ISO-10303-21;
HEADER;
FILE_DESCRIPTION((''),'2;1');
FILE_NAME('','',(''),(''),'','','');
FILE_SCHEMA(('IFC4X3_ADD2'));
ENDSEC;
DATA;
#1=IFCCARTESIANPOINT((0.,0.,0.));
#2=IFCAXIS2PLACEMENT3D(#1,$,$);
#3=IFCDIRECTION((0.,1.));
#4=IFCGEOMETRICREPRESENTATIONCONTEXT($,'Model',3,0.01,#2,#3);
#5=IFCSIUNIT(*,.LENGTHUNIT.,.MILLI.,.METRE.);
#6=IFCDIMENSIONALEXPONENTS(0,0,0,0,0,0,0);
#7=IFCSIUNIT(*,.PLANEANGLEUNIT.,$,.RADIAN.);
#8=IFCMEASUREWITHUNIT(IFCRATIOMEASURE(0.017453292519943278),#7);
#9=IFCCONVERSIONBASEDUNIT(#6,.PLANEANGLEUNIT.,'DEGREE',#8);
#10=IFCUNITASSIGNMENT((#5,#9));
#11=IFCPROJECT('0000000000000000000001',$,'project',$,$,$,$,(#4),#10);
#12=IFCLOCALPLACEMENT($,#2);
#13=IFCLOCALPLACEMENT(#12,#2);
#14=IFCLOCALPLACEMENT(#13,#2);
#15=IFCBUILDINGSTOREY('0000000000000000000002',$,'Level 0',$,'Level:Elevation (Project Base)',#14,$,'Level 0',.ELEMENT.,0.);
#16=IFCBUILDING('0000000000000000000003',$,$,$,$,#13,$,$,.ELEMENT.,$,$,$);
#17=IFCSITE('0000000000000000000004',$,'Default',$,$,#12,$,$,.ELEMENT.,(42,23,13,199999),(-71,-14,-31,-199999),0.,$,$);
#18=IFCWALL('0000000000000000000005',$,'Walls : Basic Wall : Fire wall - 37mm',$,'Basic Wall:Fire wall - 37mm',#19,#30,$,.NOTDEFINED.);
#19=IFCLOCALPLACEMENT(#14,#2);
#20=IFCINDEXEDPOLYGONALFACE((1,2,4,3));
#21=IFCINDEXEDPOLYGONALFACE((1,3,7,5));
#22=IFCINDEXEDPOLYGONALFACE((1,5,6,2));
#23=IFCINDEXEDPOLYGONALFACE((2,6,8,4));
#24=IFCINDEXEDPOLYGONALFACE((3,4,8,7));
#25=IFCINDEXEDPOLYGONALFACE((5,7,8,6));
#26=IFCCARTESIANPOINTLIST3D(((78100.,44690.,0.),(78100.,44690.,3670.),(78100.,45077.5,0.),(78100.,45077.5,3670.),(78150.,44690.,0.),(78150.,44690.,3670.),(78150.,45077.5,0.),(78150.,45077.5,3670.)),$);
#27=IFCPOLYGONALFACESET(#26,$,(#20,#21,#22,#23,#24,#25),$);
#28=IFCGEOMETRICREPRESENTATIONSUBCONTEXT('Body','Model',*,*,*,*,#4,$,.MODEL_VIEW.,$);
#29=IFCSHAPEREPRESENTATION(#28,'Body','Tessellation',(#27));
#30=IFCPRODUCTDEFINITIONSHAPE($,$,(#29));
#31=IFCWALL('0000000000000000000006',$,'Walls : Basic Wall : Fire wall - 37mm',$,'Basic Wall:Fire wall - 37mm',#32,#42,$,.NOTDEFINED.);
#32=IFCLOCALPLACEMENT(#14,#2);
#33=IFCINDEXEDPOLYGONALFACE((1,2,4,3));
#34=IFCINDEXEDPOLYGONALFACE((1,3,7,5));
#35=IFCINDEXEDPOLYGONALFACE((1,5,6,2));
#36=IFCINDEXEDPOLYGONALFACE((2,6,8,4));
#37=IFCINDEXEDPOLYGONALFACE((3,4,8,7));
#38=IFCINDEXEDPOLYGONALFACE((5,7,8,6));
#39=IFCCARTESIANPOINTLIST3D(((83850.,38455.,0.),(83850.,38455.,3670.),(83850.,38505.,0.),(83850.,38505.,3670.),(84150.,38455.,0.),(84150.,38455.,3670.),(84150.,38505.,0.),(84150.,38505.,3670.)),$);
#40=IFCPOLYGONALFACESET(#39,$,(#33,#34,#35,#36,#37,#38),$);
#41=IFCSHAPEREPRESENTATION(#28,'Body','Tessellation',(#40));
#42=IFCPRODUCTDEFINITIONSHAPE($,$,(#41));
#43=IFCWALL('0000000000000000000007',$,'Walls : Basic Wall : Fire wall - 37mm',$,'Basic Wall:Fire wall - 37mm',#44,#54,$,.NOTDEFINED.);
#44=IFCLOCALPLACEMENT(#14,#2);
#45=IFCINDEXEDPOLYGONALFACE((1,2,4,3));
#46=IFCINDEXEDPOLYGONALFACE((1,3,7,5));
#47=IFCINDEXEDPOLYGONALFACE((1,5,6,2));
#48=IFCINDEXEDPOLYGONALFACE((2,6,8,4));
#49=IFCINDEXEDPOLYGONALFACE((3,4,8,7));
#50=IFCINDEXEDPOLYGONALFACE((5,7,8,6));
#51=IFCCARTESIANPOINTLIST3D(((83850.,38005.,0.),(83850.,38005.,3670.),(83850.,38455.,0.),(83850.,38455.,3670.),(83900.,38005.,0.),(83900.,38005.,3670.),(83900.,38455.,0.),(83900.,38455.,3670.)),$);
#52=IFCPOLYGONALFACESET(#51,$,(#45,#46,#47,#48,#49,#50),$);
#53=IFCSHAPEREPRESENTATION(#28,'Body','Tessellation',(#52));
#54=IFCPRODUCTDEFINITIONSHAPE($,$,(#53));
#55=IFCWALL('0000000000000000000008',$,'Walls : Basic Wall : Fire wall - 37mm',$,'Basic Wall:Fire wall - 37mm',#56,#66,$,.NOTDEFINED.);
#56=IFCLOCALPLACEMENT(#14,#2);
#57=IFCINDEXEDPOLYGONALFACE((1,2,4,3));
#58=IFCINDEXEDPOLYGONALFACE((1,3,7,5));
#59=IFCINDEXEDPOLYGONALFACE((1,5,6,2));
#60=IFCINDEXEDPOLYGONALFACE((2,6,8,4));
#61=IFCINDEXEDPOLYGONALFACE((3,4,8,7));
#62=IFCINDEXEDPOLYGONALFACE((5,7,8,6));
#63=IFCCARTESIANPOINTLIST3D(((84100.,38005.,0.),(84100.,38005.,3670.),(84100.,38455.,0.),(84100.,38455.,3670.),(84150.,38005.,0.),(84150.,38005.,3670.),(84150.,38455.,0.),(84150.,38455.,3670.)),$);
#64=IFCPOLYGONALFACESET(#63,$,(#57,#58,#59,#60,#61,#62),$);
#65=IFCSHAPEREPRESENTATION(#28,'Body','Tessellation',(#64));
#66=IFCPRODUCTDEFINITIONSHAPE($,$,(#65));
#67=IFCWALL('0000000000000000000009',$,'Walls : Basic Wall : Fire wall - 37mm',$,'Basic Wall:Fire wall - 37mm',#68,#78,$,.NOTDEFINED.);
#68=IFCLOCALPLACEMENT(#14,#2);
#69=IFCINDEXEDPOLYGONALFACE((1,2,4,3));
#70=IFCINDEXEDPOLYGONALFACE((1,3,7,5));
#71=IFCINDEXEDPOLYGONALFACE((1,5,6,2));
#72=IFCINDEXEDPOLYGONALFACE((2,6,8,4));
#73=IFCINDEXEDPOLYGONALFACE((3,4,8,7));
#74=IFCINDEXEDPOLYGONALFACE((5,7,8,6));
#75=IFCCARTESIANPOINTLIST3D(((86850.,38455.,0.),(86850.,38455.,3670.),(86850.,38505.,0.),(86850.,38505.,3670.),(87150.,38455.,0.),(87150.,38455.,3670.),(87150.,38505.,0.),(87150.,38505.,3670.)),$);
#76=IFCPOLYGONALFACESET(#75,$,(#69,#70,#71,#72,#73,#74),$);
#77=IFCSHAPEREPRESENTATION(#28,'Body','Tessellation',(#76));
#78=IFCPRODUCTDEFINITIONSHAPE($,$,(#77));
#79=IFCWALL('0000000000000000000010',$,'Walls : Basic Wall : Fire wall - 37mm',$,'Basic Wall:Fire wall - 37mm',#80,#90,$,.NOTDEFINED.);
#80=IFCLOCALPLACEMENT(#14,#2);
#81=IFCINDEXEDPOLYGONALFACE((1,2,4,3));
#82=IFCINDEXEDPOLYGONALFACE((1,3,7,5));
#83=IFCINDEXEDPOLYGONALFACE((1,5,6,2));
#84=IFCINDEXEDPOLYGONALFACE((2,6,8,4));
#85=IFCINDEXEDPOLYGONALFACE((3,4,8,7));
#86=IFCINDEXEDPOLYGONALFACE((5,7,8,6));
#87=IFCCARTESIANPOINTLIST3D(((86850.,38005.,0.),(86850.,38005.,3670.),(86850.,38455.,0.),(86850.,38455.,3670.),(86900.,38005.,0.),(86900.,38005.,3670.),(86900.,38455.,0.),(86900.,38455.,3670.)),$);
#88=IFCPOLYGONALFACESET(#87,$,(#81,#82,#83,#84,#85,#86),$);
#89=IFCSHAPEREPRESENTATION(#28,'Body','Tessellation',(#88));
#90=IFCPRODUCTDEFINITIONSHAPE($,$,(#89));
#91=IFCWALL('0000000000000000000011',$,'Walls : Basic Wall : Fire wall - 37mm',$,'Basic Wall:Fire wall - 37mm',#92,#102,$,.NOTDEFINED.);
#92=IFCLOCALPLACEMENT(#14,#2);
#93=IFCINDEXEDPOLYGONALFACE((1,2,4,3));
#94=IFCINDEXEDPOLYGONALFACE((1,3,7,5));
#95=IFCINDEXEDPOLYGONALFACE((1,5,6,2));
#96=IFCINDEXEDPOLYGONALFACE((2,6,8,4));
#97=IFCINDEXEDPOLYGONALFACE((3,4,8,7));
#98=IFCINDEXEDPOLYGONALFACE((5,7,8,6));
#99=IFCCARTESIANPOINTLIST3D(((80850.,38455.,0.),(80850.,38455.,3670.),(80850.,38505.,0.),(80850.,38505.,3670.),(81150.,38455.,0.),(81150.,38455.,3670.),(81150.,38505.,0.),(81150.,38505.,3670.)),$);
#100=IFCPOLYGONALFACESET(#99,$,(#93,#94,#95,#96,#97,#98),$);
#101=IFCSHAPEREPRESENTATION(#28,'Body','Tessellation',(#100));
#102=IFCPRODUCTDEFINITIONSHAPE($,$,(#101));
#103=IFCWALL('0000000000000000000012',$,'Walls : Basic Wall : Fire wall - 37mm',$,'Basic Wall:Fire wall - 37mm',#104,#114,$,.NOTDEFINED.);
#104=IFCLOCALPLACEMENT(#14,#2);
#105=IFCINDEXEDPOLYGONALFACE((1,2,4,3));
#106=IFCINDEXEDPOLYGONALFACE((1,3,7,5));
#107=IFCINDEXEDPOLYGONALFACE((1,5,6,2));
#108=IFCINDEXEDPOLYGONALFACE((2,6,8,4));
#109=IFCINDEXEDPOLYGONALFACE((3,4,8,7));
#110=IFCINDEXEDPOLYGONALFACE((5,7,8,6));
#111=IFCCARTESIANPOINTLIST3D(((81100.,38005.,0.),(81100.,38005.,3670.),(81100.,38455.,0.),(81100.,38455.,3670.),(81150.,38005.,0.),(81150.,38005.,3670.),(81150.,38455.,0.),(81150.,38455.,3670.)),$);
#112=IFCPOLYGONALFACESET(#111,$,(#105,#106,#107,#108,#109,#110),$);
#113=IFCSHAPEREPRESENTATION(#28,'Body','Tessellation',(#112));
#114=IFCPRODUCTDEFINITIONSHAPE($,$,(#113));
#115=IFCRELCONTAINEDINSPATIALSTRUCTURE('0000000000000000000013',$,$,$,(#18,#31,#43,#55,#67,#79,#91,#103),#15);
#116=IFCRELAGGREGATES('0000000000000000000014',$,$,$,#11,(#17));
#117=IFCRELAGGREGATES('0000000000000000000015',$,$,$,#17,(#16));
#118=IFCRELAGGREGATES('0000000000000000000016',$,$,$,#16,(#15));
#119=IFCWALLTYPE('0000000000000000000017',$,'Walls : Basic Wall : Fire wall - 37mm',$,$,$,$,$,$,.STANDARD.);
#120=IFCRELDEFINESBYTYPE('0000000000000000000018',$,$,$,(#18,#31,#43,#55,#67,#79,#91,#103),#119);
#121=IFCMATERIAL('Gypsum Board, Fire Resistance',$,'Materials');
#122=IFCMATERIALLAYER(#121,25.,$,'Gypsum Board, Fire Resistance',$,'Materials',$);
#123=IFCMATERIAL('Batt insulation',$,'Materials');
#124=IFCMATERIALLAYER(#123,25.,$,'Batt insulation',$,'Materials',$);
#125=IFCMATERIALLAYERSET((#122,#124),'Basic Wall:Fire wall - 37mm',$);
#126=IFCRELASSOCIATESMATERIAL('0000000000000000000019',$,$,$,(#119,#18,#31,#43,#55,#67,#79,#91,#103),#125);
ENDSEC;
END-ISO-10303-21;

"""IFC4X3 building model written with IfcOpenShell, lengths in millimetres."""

from ifc_helpers import new_model, entity, si_unit, converted_unit, direction, frame, frame_2d, origin, place, context, subcontext, project, spatial, rectangle, extrude, material, layer, layer_set, type_object, element, save


model = new_model("IFC4X3")

# Units and contexts
model_context = context("Model", 3, precision=0.01, world=origin(), true_north=direction((0.0, 1.0)))
body_context = subcontext(model_context, "Body", "Model", "MODEL_VIEW")
ifc_project = project(units=[si_unit("LENGTHUNIT", "METRE", prefix="MILLI"), converted_unit("PLANEANGLEUNIT", "DEGREE", entity("IfcRatioMeasure", 0.017453292519943278), si_unit("PLANEANGLEUNIT", "RADIAN"), dimensions=[0, 0, 0, 0, 0, 0, 0])], contexts=[model_context])

# Site, building, storey
site_placement = place(None, origin())
site = spatial("IfcSite", under=ifc_project, at=site_placement, Name="Default", CompositionType="ELEMENT", RefLatitude=(42, 23, 13, 199999), RefLongitude=(-71, -14, -31, -199999), RefElevation=0.0)
building_placement = place(site_placement, origin())
building = spatial("IfcBuilding", under=site, at=building_placement, CompositionType="ELEMENT")
storey_placement = place(building_placement, origin())
storey = spatial("IfcBuildingStorey", under=building, at=storey_placement, Name="Level 0", ObjectType="Level:Elevation (Project Base)", LongName="Level 0", CompositionType="ELEMENT", Elevation=0.0)

# Walls
ifc_material_1 = material(Name="Gypsum Board, Fire Resistance", Category="Materials")
ifc_layer_1 = layer(ifc_material_1, 25.0, Name="Gypsum Board, Fire Resistance", Category="Materials")
ifc_material_2 = material(Name="Batt insulation", Category="Materials")
ifc_layer_2 = layer(ifc_material_2, 25.0, Name="Batt insulation", Category="Materials")
ifc_layer_set = layer_set([ifc_layer_1, ifc_layer_2], Name="Basic Wall:Fire wall - 37mm")
wall_type = type_object("IfcWallType", Name="Walls : Basic Wall : Fire wall - 37mm", PredefinedType="STANDARD", material=ifc_layer_set)
wall_1_placement = place(storey_placement, frame((78125.0, 45077.5, 0.0), z_axis=(0.0, 0.0, 1.0), x_axis=(0.0, -1.0, 0.0)))
element("IfcWall", 1, at=wall_1_placement, inside=storey, type_object=wall_type, material=ifc_layer_set, Name="Walls : Basic Wall : Fire wall - 37mm", ObjectType="Basic Wall:Fire wall - 37mm", PredefinedType="NOTDEFINED", context=body_context, shape_type="SweptSolid", body=[
    extrude(rectangle(XDim=387.5, YDim=50.0, at=frame_2d((193.7, 0.0), x_axis=(-1.0, 0.0))), origin(), (0.0, 0.0, 1.0), 3670.0),
])
wall_2_placement = place(storey_placement, frame((83850.0, 38480.0, 0.0)))
element("IfcWall", 2, at=wall_2_placement, inside=storey, type_object=wall_type, material=ifc_layer_set, Name="Walls : Basic Wall : Fire wall - 37mm", ObjectType="Basic Wall:Fire wall - 37mm", PredefinedType="NOTDEFINED", context=body_context, shape_type="SweptSolid", body=[
    extrude(rectangle(XDim=300.0, YDim=50.0, at=frame_2d((150.0, 0.0), x_axis=(-1.0, 0.0))), origin(), (0.0, 0.0, 1.0), 3670.0),
])
for number, where, z_axis, x_axis, name in (
    (3, (83875.0, 38455.0, 0.0), (0.0, 0.0, 1.0), (0.0, -1.0, 0.0), "Walls : Basic Wall : Fire wall - 37mm"),
    (4, (84125.0, 38455.0, 0.0), (0.0, 0.0, 1.0), (0.0, -1.0, 0.0), "Walls : Basic Wall : Fire wall - 37mm"),
):
    element("IfcWall", number, at=place(storey_placement, frame(where, z_axis=z_axis, x_axis=x_axis)), inside=storey, type_object=wall_type, material=ifc_layer_set, Name=name, ObjectType="Basic Wall:Fire wall - 37mm", PredefinedType="NOTDEFINED", context=body_context, shape_type="SweptSolid", body=[
        extrude(rectangle(XDim=450.0, YDim=50.0, at=frame_2d((225.0, 0.0), x_axis=(-1.0, 0.0))), origin(), (0.0, 0.0, 1.0), 3670.0),
    ])
wall_3_placement = place(storey_placement, frame((86850.0, 38480.0, 0.0)))
element("IfcWall", 5, at=wall_3_placement, inside=storey, type_object=wall_type, material=ifc_layer_set, Name="Walls : Basic Wall : Fire wall - 37mm", ObjectType="Basic Wall:Fire wall - 37mm", PredefinedType="NOTDEFINED", context=body_context, shape_type="SweptSolid", body=[
    extrude(rectangle(XDim=300.0, YDim=50.0, at=frame_2d((150.0, 0.0), x_axis=(-1.0, 0.0))), origin(), (0.0, 0.0, 1.0), 3670.0),
])
wall_4_placement = place(storey_placement, frame((86875.0, 38455.0, 0.0), z_axis=(0.0, 0.0, 1.0), x_axis=(0.0, -1.0, 0.0)))
element("IfcWall", 6, at=wall_4_placement, inside=storey, type_object=wall_type, material=ifc_layer_set, Name="Walls : Basic Wall : Fire wall - 37mm", ObjectType="Basic Wall:Fire wall - 37mm", PredefinedType="NOTDEFINED", context=body_context, shape_type="SweptSolid", body=[
    extrude(rectangle(XDim=450.0, YDim=50.0, at=frame_2d((225.0, 0.0), x_axis=(-1.0, 0.0))), origin(), (0.0, 0.0, 1.0), 3670.0),
])
wall_5_placement = place(storey_placement, frame((80850.0, 38480.0, 0.0)))
element("IfcWall", 7, at=wall_5_placement, inside=storey, type_object=wall_type, material=ifc_layer_set, Name="Walls : Basic Wall : Fire wall - 37mm", ObjectType="Basic Wall:Fire wall - 37mm", PredefinedType="NOTDEFINED", context=body_context, shape_type="SweptSolid", body=[
    extrude(rectangle(XDim=300.0, YDim=50.0, at=frame_2d((150.0, 0.0), x_axis=(-1.0, 0.0))), origin(), (0.0, 0.0, 1.0), 3670.0),
])
wall_6_placement = place(storey_placement, frame((81125.0, 38455.0, 0.0), z_axis=(0.0, 0.0, 1.0), x_axis=(0.0, -1.0, 0.0)))
element("IfcWall", 8, at=wall_6_placement, inside=storey, type_object=wall_type, material=ifc_layer_set, Name="Walls : Basic Wall : Fire wall - 37mm", ObjectType="Basic Wall:Fire wall - 37mm", PredefinedType="NOTDEFINED", context=body_context, shape_type="SweptSolid", body=[
    extrude(rectangle(XDim=450.0, YDim=50.0, at=frame_2d((225.0, 0.0), x_axis=(-1.0, 0.0))), origin(), (0.0, 0.0, 1.0), 3670.0),
])

save(model, "model.ifc")
